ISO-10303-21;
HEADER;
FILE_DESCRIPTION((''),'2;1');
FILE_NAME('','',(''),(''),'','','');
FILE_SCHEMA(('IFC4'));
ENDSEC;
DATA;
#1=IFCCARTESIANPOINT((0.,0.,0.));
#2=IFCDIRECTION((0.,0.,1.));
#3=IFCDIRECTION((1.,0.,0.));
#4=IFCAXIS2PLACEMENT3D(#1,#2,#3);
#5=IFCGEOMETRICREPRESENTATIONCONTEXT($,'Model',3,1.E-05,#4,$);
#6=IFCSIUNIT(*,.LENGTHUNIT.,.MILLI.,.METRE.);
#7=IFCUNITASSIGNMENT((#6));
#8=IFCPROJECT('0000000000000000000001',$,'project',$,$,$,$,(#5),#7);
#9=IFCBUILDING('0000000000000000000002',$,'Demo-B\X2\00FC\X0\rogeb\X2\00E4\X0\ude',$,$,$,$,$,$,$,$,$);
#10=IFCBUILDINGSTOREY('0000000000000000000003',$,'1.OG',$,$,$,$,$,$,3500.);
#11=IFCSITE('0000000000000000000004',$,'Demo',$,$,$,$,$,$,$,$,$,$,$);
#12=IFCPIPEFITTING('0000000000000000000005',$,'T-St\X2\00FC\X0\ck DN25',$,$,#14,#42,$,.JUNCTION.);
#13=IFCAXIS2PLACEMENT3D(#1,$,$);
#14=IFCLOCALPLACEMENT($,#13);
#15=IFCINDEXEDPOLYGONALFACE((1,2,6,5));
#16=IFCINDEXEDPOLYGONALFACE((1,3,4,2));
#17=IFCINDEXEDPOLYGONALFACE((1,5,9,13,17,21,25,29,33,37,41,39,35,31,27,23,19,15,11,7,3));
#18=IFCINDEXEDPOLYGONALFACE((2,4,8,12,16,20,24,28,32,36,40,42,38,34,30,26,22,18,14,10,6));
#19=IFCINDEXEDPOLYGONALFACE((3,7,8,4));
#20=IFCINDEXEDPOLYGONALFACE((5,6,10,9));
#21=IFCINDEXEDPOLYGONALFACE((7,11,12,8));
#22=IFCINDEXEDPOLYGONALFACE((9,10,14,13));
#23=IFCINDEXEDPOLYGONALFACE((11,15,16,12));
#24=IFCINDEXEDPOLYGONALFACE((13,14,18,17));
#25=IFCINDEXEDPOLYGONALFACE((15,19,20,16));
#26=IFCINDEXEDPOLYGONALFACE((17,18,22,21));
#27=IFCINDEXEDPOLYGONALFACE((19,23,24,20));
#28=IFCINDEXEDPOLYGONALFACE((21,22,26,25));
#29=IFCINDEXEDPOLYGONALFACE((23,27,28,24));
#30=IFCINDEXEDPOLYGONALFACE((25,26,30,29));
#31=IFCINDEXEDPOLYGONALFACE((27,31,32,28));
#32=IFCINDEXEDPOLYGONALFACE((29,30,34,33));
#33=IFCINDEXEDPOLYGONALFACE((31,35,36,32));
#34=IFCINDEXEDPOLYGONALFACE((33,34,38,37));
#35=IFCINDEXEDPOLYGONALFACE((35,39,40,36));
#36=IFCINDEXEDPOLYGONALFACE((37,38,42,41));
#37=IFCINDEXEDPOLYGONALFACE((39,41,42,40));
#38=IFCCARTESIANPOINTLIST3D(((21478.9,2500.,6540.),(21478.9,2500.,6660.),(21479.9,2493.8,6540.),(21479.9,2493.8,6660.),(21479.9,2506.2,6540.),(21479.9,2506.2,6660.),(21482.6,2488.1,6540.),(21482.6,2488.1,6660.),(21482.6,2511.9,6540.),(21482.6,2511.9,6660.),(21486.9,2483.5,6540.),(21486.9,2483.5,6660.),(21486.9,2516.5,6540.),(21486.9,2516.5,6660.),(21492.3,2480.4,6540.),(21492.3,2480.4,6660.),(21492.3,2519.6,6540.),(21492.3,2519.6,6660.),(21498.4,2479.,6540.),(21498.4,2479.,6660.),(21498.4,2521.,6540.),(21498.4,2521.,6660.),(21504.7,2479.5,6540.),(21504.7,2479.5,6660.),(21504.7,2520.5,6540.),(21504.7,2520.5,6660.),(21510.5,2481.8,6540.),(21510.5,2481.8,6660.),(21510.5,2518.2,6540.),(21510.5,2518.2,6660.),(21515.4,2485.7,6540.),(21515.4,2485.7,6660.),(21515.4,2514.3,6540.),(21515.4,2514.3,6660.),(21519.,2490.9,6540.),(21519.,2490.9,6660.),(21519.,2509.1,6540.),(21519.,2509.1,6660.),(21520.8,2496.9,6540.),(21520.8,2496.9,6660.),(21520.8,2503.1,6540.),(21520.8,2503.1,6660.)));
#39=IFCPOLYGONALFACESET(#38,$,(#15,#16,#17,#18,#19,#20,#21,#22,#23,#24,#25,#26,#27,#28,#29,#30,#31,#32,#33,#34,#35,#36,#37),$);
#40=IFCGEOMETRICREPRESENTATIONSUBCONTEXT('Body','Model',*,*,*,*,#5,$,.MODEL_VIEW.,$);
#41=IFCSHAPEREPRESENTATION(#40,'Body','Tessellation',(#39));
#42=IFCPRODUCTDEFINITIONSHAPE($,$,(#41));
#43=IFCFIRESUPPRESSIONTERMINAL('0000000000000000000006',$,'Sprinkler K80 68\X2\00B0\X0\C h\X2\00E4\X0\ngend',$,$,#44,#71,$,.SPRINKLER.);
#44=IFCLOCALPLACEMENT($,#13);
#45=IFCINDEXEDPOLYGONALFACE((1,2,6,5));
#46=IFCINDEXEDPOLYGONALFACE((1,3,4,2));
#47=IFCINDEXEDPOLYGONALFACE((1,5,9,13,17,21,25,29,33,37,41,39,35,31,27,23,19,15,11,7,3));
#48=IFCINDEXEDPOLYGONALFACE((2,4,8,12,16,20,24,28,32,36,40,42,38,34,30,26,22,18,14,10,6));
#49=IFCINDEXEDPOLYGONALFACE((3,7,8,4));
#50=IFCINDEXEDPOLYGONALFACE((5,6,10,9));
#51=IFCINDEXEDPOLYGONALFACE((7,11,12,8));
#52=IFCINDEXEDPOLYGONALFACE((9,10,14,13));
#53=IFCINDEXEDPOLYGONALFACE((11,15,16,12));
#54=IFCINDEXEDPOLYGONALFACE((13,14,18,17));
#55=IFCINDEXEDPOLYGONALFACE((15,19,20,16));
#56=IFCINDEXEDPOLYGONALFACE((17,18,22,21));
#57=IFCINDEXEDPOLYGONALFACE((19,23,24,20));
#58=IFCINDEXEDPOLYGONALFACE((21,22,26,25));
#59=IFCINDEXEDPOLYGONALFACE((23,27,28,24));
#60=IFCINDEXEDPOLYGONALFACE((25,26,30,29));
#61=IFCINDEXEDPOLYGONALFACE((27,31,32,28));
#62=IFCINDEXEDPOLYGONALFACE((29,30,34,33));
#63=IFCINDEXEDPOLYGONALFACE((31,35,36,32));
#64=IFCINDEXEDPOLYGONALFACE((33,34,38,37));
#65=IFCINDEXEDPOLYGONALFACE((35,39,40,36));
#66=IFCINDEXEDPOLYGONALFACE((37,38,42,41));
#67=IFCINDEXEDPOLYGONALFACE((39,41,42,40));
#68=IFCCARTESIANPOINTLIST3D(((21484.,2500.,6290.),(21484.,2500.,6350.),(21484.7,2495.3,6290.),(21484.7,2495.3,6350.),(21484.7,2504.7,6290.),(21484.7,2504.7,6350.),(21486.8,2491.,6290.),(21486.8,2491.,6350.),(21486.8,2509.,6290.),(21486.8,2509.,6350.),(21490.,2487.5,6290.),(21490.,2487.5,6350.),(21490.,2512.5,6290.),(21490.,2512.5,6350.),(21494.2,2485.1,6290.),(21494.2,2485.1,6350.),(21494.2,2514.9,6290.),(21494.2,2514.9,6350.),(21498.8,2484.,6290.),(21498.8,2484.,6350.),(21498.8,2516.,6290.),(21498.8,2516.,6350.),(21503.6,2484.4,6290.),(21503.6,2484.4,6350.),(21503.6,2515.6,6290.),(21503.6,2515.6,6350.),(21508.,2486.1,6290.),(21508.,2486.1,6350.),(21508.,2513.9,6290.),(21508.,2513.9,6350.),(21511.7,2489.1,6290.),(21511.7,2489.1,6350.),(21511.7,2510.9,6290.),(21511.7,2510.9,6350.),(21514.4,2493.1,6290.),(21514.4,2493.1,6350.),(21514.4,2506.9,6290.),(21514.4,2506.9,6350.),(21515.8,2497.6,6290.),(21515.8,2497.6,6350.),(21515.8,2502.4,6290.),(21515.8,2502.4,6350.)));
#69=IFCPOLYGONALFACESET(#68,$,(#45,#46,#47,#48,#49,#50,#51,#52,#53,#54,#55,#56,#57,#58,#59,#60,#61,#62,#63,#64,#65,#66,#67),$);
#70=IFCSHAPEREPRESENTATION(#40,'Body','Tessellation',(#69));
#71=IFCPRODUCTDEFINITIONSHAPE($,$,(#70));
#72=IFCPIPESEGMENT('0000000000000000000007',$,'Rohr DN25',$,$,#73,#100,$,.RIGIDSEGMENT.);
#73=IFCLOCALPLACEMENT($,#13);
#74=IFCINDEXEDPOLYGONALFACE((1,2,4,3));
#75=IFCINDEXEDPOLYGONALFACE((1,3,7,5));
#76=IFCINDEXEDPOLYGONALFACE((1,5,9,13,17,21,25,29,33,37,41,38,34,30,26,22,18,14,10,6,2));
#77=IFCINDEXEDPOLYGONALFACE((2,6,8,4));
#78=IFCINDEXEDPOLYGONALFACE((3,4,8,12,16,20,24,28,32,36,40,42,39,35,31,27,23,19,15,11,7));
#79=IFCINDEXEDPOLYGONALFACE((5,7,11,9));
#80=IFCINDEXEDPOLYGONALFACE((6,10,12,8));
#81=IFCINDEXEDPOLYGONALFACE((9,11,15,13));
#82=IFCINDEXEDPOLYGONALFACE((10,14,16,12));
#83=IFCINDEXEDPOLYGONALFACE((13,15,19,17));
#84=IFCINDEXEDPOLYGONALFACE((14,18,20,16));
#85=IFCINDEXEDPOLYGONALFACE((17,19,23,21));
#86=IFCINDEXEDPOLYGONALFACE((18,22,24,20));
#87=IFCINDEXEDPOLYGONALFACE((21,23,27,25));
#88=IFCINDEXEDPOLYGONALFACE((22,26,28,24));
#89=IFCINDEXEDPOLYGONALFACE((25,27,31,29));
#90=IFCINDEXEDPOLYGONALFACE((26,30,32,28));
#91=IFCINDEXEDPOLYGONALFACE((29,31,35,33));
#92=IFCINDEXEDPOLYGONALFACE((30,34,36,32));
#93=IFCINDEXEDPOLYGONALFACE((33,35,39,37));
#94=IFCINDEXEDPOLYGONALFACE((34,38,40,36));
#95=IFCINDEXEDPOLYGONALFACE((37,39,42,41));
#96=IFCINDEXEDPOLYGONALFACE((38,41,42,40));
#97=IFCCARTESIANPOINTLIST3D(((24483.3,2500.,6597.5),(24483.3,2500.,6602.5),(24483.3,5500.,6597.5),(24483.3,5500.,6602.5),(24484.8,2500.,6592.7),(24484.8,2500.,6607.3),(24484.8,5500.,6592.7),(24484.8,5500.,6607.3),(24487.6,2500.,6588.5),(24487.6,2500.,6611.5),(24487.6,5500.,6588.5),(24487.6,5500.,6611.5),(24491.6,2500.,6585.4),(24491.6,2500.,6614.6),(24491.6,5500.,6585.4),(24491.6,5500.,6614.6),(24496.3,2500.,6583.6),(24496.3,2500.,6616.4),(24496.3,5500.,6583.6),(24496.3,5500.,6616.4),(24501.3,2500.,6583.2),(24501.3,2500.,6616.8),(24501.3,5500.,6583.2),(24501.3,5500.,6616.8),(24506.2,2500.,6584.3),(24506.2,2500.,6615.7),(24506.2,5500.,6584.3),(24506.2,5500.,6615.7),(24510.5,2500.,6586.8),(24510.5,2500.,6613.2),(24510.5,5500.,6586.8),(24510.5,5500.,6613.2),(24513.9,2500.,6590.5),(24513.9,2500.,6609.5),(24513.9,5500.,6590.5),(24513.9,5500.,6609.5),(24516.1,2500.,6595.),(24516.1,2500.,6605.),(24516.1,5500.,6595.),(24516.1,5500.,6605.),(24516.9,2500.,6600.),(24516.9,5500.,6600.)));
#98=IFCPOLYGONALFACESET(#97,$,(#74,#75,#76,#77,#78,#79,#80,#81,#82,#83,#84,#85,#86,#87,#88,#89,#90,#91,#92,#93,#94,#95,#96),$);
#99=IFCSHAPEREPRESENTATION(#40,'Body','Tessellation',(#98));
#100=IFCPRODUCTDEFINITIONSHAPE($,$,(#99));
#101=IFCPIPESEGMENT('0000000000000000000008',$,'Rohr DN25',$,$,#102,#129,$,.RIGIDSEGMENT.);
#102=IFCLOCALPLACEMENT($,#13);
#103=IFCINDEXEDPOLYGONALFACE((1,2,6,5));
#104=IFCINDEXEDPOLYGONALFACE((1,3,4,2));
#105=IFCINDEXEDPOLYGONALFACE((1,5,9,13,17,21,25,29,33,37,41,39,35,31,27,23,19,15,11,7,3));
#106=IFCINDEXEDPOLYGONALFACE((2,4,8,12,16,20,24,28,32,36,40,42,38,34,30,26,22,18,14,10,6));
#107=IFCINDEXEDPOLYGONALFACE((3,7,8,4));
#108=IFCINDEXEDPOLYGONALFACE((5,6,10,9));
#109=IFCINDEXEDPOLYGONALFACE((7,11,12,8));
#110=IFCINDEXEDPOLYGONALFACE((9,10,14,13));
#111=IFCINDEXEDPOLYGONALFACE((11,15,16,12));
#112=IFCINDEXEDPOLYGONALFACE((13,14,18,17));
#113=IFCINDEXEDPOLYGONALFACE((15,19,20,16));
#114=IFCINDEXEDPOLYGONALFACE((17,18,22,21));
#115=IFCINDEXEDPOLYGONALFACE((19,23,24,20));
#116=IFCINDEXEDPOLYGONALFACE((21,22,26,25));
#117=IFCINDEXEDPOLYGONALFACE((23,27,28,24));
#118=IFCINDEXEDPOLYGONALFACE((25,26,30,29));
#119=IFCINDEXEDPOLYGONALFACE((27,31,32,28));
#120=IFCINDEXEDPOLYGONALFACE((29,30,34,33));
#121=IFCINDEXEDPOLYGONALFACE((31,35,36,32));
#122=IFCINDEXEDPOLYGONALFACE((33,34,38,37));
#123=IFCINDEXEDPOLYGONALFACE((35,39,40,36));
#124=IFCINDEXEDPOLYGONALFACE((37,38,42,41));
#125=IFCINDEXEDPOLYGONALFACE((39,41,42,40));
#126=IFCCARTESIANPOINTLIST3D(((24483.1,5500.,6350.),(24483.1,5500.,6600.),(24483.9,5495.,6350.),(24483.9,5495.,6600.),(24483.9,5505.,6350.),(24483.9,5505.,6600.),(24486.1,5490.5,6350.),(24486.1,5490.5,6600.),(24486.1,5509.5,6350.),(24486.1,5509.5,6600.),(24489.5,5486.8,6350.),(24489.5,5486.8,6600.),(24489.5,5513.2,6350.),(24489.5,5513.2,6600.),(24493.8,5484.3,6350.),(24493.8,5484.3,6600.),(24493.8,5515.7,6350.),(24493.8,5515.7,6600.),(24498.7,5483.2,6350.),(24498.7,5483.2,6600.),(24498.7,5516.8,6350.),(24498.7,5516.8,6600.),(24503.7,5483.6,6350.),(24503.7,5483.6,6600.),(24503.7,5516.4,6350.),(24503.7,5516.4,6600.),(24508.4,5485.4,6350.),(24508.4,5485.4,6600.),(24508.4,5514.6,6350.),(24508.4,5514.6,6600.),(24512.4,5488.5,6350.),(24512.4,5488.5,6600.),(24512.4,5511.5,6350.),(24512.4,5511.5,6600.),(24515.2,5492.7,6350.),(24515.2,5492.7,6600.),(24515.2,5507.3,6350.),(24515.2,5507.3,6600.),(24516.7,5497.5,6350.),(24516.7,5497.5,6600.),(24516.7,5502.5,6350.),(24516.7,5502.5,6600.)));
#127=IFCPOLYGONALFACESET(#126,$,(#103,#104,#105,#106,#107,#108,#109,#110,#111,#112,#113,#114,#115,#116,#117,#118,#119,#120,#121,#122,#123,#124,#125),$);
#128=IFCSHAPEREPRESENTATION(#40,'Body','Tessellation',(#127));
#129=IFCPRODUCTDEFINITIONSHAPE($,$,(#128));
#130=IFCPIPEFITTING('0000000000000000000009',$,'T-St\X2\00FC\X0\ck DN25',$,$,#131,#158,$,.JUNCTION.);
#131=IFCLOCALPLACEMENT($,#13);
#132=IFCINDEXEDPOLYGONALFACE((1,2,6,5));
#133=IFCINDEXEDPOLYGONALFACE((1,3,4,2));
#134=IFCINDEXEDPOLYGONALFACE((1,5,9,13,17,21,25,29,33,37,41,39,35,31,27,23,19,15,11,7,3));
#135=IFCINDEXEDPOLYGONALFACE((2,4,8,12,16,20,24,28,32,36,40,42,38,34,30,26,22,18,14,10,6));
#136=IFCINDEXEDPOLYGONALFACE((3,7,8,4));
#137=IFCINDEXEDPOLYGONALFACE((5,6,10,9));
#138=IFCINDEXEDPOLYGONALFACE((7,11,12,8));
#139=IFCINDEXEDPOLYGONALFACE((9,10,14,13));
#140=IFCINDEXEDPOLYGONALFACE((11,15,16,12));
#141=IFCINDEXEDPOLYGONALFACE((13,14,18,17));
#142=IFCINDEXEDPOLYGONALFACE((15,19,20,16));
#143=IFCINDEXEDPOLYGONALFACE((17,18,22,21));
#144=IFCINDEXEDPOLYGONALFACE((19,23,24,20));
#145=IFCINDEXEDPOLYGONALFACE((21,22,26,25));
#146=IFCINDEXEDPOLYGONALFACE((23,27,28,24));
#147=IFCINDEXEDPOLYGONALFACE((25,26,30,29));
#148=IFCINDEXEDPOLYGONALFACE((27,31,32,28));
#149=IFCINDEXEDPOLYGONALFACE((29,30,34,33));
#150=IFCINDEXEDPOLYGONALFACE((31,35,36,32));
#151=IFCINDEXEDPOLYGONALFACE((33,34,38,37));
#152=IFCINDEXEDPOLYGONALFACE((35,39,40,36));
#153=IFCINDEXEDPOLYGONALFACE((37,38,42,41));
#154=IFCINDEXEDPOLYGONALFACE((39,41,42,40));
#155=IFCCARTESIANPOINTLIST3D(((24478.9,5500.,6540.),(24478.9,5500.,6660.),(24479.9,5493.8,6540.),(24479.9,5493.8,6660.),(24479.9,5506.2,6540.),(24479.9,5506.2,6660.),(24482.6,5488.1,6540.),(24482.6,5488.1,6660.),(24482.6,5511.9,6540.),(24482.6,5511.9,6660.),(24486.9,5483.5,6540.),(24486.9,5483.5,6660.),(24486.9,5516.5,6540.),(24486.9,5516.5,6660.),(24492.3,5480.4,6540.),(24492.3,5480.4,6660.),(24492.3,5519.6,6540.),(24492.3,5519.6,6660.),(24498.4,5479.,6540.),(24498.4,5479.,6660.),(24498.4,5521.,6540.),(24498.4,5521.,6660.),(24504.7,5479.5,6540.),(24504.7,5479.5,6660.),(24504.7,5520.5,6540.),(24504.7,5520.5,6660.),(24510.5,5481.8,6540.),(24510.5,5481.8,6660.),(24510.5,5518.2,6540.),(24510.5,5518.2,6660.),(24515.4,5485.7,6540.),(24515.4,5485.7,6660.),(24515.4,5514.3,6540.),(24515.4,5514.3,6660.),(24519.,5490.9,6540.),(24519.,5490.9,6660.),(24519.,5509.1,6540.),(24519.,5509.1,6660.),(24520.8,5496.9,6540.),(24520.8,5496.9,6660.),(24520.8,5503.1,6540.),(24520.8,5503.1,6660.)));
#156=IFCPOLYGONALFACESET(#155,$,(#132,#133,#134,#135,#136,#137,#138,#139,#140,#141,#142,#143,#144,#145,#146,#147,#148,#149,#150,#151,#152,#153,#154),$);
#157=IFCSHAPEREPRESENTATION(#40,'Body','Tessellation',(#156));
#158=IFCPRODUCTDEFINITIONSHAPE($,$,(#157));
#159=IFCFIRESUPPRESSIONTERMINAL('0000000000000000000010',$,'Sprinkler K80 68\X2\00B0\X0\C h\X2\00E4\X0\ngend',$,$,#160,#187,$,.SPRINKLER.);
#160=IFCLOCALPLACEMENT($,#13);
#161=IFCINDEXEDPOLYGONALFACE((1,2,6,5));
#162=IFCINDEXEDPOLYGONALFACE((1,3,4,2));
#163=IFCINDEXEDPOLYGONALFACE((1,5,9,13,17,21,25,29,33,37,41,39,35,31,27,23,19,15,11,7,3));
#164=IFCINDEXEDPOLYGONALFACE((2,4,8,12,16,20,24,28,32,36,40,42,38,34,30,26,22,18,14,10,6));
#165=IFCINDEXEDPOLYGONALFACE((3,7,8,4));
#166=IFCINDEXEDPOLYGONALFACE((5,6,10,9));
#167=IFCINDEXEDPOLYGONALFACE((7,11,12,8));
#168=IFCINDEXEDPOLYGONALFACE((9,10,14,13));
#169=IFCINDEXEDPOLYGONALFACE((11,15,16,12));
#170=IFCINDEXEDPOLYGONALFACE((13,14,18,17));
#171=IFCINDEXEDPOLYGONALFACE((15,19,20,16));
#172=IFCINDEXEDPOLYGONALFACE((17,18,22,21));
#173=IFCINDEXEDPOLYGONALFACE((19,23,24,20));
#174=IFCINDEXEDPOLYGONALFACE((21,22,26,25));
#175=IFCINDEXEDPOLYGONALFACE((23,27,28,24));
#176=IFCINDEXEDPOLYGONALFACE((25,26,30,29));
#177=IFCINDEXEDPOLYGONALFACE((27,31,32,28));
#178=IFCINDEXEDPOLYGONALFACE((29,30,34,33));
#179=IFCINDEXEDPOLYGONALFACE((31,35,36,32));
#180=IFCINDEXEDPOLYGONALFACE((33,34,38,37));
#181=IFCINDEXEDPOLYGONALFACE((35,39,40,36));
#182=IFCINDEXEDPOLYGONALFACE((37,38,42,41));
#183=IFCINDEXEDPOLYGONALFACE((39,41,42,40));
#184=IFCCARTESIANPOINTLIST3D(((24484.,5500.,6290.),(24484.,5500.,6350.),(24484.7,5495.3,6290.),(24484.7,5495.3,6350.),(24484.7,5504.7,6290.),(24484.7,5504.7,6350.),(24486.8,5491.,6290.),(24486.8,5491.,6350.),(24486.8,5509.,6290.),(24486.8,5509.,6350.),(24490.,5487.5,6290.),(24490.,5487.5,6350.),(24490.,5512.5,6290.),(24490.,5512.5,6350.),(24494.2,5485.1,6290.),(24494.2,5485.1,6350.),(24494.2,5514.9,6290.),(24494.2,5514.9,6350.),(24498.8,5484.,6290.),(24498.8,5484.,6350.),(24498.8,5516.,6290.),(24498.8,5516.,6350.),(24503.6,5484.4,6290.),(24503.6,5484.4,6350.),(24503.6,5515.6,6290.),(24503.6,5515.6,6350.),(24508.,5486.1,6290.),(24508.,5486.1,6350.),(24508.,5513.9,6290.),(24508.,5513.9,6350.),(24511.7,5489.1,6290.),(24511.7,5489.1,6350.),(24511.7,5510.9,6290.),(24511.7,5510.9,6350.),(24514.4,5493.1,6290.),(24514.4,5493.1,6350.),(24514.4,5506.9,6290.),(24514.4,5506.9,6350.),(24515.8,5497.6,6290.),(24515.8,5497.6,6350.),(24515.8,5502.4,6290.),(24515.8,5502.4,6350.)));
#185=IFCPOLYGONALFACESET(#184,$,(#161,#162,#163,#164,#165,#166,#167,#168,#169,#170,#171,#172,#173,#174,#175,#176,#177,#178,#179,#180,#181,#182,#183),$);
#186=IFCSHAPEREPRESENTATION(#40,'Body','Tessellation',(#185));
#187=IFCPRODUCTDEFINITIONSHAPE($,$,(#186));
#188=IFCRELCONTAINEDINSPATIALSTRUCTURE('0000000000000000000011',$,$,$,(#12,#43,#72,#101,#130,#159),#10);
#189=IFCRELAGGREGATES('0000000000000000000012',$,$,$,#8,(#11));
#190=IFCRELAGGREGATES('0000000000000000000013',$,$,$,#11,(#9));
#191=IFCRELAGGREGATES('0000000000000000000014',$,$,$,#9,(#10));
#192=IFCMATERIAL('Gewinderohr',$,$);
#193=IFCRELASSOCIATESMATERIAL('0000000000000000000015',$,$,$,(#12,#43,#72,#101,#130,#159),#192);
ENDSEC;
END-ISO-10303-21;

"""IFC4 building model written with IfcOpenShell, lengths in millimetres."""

from ifc_helpers import new_model, si_unit, frame, origin_with_axes, place, context, subcontext, project, spatial, circle, extrude, material, element, save


model = new_model("IFC4")

# Units and contexts
model_context = context("Model", 3, precision=1e-05, world=origin_with_axes())
body_context = subcontext(model_context, "Body", "Model", "MODEL_VIEW")
ifc_project = project(units=[si_unit("LENGTHUNIT", "METRE", prefix="MILLI")], contexts=[model_context])

# Site, building, storey
site = spatial("IfcSite", under=ifc_project, Name="Demo")
building = spatial("IfcBuilding", under=site, Name="Demo-Bürogebäude")
storey = spatial("IfcBuildingStorey", under=building, Name="1.OG", Elevation=3500.0)

# Shared definitions
ifc_material_1 = material(Name="Gewinderohr")

# Pipe fitting
pipe_fitting_1_placement = place(None, frame((21500.0, 2500.0, 6660.0), z_axis=(0.0, 0.0, -1.0), x_axis=(-1.0, 0.0, 0.0)))
element("IfcPipeFitting", 1, at=pipe_fitting_1_placement, inside=storey, material=ifc_material_1, Name="T-Stück DN25", PredefinedType="JUNCTION", context=body_context, shape_type="SweptSolid", body=[
    extrude(circle(Radius=21.1), origin_with_axes(), (0.0, 0.0, 1.0), 120.0),
])

# Fire suppression terminal
fire_suppression_terminal_1_placement = place(None, frame((21500.0, 2500.0, 6350.0), z_axis=(0.0, 0.0, -1.0), x_axis=(-1.0, 0.0, 0.0)))
element("IfcFireSuppressionTerminal", 2, at=fire_suppression_terminal_1_placement, inside=storey, material=ifc_material_1, Name="Sprinkler K80 68°C hängend", PredefinedType="SPRINKLER", context=body_context, shape_type="SweptSolid", body=[
    extrude(circle(Radius=16.0), origin_with_axes(), (0.0, 0.0, 1.0), 60.0),
])

# Pipe segments
pipe_segment_1_placement = place(None, frame((24500.0, 5500.0, 6600.0), z_axis=(0.0, -1.0, 0.0), x_axis=(1.0, 0.0, 0.0)))
element("IfcPipeSegment", 3, at=pipe_segment_1_placement, inside=storey, material=ifc_material_1, Name="Rohr DN25", PredefinedType="RIGIDSEGMENT", context=body_context, shape_type="SweptSolid", body=[
    extrude(circle(Radius=16.9), origin_with_axes(), (0.0, 0.0, 1.0), 3000.0),
])
pipe_segment_2_placement = place(None, frame((24500.0, 5500.0, 6600.0), z_axis=(0.0, 0.0, -1.0), x_axis=(-1.0, 0.0, 0.0)))
element("IfcPipeSegment", 4, at=pipe_segment_2_placement, inside=storey, material=ifc_material_1, Name="Rohr DN25", PredefinedType="RIGIDSEGMENT", context=body_context, shape_type="SweptSolid", body=[
    extrude(circle(Radius=16.9), origin_with_axes(), (0.0, 0.0, 1.0), 250.0),
])

# Pipe fitting
pipe_fitting_2_placement = place(None, frame((24500.0, 5500.0, 6660.0), z_axis=(0.0, 0.0, -1.0), x_axis=(-1.0, 0.0, 0.0)))
element("IfcPipeFitting", 5, at=pipe_fitting_2_placement, inside=storey, material=ifc_material_1, Name="T-Stück DN25", PredefinedType="JUNCTION", context=body_context, shape_type="SweptSolid", body=[
    extrude(circle(Radius=21.1), origin_with_axes(), (0.0, 0.0, 1.0), 120.0),
])

# Fire suppression terminal
fire_suppression_terminal_2_placement = place(None, frame((24500.0, 5500.0, 6350.0), z_axis=(0.0, 0.0, -1.0), x_axis=(-1.0, 0.0, 0.0)))
element("IfcFireSuppressionTerminal", 6, at=fire_suppression_terminal_2_placement, inside=storey, material=ifc_material_1, Name="Sprinkler K80 68°C hängend", PredefinedType="SPRINKLER", context=body_context, shape_type="SweptSolid", body=[
    extrude(circle(Radius=16.0), origin_with_axes(), (0.0, 0.0, 1.0), 60.0),
])

save(model, "model.ifc")
